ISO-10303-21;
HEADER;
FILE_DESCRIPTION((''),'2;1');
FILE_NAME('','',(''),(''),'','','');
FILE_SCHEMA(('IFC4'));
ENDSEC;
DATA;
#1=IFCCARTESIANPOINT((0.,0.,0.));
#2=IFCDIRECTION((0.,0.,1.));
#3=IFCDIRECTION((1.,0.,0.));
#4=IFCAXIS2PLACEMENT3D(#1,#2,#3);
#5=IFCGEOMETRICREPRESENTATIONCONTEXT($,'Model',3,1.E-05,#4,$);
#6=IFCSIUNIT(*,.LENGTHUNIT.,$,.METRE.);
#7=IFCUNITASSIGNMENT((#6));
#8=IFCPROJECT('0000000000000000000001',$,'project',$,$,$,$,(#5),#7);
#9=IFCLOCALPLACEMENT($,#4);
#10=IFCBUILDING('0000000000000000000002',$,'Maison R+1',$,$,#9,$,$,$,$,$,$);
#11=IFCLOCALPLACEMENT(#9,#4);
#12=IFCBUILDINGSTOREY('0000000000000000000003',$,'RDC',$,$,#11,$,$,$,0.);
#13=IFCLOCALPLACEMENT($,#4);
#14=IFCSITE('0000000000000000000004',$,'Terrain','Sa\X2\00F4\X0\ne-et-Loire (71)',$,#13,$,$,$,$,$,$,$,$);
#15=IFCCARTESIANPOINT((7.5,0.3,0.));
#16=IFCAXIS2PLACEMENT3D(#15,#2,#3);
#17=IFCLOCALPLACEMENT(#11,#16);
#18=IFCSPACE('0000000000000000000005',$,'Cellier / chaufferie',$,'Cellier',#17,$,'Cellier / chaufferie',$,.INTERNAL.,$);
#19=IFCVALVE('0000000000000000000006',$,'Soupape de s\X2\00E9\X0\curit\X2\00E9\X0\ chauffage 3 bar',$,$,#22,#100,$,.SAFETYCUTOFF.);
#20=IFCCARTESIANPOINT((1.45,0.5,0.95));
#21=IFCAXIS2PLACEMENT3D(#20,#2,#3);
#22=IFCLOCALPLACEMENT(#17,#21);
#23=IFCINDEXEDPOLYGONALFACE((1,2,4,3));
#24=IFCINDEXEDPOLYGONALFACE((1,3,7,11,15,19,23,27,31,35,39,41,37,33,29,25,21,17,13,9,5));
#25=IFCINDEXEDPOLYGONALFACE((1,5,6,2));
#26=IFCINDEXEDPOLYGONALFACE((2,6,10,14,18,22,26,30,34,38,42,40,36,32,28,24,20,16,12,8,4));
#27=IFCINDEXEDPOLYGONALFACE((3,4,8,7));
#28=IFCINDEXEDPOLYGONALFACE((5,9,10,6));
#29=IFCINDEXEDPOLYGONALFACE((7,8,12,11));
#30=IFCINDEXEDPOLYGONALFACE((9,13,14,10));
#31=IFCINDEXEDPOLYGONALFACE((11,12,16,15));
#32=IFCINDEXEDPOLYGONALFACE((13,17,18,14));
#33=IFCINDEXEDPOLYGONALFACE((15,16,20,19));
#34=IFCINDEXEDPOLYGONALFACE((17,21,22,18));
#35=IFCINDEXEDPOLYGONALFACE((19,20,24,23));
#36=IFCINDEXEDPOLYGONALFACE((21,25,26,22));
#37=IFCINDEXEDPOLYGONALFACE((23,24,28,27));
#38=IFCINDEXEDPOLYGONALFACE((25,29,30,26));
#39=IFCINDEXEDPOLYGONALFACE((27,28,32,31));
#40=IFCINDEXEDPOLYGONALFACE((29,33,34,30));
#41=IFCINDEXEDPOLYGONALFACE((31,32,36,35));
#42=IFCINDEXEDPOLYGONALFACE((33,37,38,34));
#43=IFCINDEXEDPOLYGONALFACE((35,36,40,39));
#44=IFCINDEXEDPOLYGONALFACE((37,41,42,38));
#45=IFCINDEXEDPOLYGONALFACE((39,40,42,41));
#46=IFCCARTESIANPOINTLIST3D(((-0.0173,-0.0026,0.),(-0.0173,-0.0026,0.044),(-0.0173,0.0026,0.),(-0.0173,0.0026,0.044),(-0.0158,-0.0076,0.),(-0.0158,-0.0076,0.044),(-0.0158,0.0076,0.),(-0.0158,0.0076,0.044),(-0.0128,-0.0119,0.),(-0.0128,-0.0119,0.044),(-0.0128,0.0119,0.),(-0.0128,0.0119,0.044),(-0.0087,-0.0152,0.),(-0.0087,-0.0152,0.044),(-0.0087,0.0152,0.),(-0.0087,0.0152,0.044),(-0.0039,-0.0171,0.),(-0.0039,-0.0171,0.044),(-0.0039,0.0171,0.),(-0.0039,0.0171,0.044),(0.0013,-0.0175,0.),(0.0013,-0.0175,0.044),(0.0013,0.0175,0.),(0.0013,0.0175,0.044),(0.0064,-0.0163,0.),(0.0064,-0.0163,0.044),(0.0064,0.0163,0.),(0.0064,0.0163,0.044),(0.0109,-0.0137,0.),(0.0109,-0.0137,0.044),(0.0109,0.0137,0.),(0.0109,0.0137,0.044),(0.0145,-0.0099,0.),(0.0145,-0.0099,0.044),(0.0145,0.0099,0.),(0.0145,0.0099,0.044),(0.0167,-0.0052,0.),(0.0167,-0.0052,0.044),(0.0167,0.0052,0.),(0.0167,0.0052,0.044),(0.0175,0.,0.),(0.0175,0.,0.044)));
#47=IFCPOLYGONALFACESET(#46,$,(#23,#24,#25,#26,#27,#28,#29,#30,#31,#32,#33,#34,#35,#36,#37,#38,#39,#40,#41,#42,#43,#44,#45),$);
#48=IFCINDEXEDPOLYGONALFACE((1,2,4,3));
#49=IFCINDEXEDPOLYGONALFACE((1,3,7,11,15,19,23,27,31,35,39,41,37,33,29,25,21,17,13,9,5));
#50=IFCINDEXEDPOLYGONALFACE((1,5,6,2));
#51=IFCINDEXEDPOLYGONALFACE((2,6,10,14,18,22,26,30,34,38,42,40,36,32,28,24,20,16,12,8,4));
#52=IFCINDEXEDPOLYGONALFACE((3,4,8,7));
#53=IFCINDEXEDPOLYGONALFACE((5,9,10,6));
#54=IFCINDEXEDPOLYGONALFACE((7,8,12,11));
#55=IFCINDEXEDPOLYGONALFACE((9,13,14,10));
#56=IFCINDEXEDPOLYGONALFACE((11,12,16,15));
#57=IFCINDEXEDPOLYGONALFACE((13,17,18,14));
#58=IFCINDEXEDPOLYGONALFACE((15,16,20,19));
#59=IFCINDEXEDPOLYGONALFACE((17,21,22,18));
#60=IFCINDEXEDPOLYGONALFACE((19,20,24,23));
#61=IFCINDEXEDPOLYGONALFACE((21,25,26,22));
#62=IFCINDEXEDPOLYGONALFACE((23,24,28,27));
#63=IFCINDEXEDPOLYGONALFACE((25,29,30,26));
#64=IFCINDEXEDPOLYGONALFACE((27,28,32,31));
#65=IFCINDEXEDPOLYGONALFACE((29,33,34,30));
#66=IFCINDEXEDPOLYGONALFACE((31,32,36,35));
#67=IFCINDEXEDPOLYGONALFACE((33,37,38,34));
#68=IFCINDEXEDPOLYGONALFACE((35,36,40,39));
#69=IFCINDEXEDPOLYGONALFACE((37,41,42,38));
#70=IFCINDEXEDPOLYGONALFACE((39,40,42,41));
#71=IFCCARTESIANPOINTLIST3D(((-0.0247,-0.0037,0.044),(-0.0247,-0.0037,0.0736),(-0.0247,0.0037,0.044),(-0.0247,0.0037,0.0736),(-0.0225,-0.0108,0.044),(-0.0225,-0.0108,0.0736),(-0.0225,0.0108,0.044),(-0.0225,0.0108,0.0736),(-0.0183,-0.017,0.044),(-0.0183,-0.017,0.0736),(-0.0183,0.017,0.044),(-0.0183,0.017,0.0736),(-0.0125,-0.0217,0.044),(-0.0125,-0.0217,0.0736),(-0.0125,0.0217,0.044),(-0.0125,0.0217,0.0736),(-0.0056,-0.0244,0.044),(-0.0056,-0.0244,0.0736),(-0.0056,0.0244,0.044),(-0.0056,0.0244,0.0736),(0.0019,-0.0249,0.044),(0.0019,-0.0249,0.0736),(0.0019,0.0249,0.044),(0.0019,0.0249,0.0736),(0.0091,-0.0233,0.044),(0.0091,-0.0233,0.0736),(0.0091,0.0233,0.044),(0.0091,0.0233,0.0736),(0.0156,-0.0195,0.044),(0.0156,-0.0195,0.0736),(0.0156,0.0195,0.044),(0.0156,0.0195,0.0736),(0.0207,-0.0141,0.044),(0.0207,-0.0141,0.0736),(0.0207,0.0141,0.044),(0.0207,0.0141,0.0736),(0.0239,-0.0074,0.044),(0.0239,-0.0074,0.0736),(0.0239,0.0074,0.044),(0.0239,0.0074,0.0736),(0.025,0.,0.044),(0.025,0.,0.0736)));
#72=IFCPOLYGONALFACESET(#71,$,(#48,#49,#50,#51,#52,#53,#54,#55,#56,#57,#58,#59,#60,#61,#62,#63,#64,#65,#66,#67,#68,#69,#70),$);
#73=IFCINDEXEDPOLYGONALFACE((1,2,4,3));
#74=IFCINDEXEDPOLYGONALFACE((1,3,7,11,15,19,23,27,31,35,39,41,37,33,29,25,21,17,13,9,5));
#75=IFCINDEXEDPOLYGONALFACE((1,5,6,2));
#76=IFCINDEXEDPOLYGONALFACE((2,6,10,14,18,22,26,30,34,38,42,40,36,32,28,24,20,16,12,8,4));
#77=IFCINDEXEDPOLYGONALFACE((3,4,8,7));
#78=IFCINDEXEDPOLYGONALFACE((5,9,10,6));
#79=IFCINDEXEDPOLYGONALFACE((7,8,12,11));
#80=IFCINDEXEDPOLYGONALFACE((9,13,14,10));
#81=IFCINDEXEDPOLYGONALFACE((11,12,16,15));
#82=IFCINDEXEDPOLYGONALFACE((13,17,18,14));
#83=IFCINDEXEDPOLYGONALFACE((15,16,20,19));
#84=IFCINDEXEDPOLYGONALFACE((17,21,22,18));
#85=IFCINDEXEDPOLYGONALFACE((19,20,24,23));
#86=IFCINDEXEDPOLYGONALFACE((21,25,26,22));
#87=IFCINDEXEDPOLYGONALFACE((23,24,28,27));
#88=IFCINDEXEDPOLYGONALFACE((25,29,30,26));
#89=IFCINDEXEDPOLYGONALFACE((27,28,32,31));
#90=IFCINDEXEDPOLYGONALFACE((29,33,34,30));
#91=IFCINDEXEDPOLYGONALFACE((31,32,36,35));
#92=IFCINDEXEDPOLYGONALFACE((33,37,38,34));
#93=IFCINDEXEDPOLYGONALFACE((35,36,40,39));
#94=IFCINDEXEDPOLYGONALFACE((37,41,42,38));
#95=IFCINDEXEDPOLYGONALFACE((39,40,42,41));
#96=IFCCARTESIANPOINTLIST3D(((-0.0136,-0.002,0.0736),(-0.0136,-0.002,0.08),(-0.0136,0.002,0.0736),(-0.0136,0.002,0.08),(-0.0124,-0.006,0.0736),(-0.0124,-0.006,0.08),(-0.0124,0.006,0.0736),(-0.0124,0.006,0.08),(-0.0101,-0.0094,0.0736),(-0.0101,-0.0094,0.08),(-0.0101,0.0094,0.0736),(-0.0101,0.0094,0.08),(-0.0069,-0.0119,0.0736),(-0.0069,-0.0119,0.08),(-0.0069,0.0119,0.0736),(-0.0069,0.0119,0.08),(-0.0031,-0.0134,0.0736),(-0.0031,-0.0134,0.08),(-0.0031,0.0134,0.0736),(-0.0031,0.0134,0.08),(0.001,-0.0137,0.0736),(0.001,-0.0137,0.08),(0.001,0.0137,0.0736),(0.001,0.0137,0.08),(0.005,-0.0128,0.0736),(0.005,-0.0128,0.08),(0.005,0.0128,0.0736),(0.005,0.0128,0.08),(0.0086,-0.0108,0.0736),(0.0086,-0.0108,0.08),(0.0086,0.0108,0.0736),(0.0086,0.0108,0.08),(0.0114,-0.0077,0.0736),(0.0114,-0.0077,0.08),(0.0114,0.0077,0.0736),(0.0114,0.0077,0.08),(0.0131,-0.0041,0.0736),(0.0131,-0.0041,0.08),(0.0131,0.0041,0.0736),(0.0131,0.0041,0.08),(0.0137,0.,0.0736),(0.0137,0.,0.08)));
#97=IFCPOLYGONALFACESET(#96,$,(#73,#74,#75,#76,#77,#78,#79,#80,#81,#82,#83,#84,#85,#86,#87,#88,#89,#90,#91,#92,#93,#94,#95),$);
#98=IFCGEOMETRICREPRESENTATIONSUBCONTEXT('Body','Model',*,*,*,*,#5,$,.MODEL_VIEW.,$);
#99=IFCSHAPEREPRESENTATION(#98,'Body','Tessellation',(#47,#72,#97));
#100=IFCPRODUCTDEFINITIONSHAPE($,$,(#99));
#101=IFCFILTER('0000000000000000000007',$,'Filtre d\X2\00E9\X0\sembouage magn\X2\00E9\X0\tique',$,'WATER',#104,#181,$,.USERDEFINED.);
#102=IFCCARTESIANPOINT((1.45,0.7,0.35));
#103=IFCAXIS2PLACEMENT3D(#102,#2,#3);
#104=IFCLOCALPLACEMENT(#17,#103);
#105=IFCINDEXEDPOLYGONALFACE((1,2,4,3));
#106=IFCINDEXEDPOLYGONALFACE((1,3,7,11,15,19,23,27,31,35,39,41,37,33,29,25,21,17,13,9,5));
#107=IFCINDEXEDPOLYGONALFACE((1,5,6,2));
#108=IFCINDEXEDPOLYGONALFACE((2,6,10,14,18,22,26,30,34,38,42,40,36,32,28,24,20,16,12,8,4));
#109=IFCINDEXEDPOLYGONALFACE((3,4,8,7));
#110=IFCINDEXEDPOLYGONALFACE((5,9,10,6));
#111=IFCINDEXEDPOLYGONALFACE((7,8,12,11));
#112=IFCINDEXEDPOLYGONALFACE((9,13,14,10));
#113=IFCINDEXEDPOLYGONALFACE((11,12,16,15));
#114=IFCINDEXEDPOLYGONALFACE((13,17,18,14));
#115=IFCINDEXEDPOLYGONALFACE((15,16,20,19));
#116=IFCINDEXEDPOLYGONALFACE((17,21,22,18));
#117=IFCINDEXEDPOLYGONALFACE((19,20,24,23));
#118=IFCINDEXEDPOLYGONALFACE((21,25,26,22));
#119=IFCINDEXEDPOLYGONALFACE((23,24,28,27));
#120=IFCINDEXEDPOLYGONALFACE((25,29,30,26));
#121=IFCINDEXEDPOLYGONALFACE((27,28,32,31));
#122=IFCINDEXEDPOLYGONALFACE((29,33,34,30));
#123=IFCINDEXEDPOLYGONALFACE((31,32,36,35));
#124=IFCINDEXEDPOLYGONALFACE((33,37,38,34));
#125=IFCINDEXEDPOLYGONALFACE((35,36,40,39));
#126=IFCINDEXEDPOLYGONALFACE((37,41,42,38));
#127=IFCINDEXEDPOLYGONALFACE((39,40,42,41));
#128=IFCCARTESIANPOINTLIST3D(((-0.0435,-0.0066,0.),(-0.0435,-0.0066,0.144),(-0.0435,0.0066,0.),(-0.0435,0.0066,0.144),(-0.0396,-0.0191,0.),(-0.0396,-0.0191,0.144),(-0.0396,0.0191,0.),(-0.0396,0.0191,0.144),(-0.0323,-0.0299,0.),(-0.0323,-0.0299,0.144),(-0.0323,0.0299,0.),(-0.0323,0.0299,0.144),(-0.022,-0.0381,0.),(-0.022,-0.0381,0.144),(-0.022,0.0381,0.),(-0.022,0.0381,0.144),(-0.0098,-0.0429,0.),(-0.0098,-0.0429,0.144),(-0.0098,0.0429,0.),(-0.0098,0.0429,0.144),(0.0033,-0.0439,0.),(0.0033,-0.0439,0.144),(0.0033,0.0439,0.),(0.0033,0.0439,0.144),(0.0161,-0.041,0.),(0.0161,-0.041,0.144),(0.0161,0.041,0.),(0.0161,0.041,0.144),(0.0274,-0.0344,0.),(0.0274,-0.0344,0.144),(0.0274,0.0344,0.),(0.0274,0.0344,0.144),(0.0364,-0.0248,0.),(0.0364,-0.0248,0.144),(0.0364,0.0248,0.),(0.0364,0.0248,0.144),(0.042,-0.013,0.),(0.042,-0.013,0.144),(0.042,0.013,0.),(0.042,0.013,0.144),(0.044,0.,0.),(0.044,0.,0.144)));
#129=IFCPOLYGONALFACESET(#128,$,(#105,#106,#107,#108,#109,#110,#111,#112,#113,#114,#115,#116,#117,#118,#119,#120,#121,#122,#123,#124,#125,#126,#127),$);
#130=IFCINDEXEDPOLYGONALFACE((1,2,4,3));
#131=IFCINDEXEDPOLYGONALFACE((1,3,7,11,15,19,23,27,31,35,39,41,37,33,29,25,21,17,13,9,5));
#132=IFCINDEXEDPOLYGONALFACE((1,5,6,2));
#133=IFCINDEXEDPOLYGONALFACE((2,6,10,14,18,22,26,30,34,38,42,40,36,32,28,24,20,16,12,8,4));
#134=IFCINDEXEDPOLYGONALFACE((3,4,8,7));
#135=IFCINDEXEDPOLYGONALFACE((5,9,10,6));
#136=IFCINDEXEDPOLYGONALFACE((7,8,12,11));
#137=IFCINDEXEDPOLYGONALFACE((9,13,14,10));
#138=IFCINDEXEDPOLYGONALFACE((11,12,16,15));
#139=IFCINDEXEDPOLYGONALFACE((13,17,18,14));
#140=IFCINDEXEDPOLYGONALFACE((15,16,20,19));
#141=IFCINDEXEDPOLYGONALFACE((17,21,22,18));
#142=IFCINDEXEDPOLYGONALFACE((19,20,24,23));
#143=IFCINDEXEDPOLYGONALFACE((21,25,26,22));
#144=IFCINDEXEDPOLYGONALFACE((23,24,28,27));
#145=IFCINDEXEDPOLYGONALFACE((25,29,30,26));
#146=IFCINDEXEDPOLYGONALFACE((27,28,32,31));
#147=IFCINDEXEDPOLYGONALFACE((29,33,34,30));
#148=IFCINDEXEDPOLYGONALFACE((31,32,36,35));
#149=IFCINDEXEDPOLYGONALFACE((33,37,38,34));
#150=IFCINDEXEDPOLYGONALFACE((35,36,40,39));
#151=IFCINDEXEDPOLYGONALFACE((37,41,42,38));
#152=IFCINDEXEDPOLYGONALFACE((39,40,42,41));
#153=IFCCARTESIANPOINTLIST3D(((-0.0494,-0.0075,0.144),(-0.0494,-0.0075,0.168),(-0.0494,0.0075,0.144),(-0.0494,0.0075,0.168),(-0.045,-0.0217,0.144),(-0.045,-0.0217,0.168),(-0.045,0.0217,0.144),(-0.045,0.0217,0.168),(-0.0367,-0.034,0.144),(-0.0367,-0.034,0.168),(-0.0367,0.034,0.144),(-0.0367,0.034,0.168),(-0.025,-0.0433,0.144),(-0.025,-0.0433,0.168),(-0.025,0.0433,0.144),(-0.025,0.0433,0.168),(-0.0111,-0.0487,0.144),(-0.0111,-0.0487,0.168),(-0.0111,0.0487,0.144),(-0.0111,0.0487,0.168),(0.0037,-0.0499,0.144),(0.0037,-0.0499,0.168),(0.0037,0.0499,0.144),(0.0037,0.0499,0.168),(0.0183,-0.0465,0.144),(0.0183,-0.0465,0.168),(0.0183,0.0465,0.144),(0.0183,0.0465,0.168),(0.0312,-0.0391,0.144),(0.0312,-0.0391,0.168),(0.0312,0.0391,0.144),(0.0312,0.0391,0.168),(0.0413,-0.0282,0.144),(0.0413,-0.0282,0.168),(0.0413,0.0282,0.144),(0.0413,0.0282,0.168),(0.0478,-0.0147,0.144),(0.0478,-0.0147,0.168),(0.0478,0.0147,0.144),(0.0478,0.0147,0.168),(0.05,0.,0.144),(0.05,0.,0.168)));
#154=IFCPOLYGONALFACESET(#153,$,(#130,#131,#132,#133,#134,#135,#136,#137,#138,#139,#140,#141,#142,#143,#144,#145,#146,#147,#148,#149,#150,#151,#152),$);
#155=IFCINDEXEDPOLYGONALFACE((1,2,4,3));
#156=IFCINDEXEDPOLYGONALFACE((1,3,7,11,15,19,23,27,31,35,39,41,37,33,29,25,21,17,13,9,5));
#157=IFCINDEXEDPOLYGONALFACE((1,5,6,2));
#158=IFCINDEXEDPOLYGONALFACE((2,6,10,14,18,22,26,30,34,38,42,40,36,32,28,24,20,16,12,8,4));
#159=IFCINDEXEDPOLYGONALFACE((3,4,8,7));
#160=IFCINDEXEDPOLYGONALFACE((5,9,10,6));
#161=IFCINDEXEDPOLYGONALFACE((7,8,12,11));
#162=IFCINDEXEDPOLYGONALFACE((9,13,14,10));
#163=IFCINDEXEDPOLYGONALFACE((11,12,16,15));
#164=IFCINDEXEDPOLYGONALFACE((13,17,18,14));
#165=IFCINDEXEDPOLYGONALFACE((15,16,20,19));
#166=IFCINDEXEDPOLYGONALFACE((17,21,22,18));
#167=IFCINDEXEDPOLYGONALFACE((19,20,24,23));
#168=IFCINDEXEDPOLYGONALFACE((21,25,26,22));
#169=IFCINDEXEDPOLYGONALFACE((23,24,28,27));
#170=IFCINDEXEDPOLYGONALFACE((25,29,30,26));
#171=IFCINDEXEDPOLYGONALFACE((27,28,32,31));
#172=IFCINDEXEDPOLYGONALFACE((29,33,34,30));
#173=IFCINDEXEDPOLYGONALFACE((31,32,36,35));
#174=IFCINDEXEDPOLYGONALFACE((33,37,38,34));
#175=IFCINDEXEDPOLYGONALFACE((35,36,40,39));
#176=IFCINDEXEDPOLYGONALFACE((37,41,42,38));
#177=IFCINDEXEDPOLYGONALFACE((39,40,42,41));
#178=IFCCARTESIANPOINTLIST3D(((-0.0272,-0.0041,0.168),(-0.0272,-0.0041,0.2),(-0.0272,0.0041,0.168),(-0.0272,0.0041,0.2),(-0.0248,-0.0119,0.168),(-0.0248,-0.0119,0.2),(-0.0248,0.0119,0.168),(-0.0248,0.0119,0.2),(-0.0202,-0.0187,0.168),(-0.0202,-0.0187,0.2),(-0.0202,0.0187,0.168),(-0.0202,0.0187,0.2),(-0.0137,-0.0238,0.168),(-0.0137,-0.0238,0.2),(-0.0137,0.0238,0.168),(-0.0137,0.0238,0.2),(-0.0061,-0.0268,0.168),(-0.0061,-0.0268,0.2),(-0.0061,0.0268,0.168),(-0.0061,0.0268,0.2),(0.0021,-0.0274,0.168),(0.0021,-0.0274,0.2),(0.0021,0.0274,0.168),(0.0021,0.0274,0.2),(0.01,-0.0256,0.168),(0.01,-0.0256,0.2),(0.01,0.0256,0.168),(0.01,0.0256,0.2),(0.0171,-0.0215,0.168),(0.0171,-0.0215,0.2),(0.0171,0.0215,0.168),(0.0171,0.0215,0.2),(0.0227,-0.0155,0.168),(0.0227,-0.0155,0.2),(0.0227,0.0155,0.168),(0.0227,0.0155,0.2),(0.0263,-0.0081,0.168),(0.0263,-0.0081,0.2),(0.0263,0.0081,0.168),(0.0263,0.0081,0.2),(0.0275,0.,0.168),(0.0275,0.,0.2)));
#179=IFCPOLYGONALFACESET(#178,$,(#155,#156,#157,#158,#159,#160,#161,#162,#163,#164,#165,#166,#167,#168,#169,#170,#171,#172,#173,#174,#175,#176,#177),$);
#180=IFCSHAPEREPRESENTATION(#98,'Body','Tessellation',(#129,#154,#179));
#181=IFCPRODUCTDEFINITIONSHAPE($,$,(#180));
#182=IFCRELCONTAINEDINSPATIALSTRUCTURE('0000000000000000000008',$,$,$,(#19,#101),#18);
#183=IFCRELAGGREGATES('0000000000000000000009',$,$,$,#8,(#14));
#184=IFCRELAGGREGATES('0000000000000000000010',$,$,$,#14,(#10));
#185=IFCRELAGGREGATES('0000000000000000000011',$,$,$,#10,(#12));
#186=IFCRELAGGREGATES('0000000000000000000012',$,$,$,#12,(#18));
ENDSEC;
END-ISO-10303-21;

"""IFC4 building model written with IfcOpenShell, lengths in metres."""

from ifc_helpers import new_model, si_unit, frame, origin_with_axes, place, context, subcontext, project, spatial, circle, extrude, element, save


model = new_model("IFC4")

# Units and contexts
model_context = context("Model", 3, precision=1e-05, world=origin_with_axes())
body_context = subcontext(model_context, "Body", "Model", "MODEL_VIEW")
ifc_project = project(units=[si_unit("LENGTHUNIT", "METRE")], contexts=[model_context])

# Site, building, storey
site_placement = place(None, origin_with_axes())
site = spatial("IfcSite", under=ifc_project, at=site_placement, Name="Terrain", Description="Saône-et-Loire (71)")
building_placement = place(None, origin_with_axes())
building = spatial("IfcBuilding", under=site, at=building_placement, Name="Maison R+1")
storey_placement = place(building_placement, origin_with_axes())
storey = spatial("IfcBuildingStorey", under=building, at=storey_placement, Name="RDC", Elevation=0.0)

# Shared definitions
space_placement = place(storey_placement, frame((7.5, 0.3, 0.0), z_axis=(0.0, 0.0, 1.0), x_axis=(1.0, 0.0, 0.0)))
space = spatial("IfcSpace", under=storey, at=space_placement, Name="Cellier / chaufferie", ObjectType="Cellier", LongName="Cellier / chaufferie", PredefinedType="INTERNAL")

# Valve
valve_1_placement = place(space_placement, frame((1.45, 0.5, 0.95), z_axis=(0.0, 0.0, 1.0), x_axis=(1.0, 0.0, 0.0)))
element("IfcValve", 1, at=valve_1_placement, inside=space, Name="Soupape de sécurité chauffage 3 bar", PredefinedType="SAFETYCUTOFF", context=body_context, shape_type="SweptSolid", body=[
    extrude(circle(Radius=0.0175), origin_with_axes(), (0.0, 0.0, 1.0), 0.044),
    extrude(circle(Radius=0.025), frame((0.0, 0.0, 0.044), z_axis=(0.0, 0.0, 1.0), x_axis=(1.0, 0.0, 0.0)), (0.0, 0.0, 1.0), 0.0296),
    extrude(circle(Radius=0.0138), frame((0.0, 0.0, 0.0736), z_axis=(0.0, 0.0, 1.0), x_axis=(1.0, 0.0, 0.0)), (0.0, 0.0, 1.0), 0.0064),
])

# Filter
ifc_filter_placement = place(space_placement, frame((1.45, 0.7, 0.35), z_axis=(0.0, 0.0, 1.0), x_axis=(1.0, 0.0, 0.0)))
element("IfcFilter", 2, at=ifc_filter_placement, inside=space, Name="Filtre désembouage magnétique", ObjectType="WATER", PredefinedType="USERDEFINED", context=body_context, shape_type="SweptSolid", body=[
    extrude(circle(Radius=0.044), origin_with_axes(), (0.0, 0.0, 1.0), 0.144),
    extrude(circle(Radius=0.05), frame((0.0, 0.0, 0.144), z_axis=(0.0, 0.0, 1.0), x_axis=(1.0, 0.0, 0.0)), (0.0, 0.0, 1.0), 0.024),
    extrude(circle(Radius=0.0275), frame((0.0, 0.0, 0.168), z_axis=(0.0, 0.0, 1.0), x_axis=(1.0, 0.0, 0.0)), (0.0, 0.0, 1.0), 0.032),
])

save(model, "model.ifc")
